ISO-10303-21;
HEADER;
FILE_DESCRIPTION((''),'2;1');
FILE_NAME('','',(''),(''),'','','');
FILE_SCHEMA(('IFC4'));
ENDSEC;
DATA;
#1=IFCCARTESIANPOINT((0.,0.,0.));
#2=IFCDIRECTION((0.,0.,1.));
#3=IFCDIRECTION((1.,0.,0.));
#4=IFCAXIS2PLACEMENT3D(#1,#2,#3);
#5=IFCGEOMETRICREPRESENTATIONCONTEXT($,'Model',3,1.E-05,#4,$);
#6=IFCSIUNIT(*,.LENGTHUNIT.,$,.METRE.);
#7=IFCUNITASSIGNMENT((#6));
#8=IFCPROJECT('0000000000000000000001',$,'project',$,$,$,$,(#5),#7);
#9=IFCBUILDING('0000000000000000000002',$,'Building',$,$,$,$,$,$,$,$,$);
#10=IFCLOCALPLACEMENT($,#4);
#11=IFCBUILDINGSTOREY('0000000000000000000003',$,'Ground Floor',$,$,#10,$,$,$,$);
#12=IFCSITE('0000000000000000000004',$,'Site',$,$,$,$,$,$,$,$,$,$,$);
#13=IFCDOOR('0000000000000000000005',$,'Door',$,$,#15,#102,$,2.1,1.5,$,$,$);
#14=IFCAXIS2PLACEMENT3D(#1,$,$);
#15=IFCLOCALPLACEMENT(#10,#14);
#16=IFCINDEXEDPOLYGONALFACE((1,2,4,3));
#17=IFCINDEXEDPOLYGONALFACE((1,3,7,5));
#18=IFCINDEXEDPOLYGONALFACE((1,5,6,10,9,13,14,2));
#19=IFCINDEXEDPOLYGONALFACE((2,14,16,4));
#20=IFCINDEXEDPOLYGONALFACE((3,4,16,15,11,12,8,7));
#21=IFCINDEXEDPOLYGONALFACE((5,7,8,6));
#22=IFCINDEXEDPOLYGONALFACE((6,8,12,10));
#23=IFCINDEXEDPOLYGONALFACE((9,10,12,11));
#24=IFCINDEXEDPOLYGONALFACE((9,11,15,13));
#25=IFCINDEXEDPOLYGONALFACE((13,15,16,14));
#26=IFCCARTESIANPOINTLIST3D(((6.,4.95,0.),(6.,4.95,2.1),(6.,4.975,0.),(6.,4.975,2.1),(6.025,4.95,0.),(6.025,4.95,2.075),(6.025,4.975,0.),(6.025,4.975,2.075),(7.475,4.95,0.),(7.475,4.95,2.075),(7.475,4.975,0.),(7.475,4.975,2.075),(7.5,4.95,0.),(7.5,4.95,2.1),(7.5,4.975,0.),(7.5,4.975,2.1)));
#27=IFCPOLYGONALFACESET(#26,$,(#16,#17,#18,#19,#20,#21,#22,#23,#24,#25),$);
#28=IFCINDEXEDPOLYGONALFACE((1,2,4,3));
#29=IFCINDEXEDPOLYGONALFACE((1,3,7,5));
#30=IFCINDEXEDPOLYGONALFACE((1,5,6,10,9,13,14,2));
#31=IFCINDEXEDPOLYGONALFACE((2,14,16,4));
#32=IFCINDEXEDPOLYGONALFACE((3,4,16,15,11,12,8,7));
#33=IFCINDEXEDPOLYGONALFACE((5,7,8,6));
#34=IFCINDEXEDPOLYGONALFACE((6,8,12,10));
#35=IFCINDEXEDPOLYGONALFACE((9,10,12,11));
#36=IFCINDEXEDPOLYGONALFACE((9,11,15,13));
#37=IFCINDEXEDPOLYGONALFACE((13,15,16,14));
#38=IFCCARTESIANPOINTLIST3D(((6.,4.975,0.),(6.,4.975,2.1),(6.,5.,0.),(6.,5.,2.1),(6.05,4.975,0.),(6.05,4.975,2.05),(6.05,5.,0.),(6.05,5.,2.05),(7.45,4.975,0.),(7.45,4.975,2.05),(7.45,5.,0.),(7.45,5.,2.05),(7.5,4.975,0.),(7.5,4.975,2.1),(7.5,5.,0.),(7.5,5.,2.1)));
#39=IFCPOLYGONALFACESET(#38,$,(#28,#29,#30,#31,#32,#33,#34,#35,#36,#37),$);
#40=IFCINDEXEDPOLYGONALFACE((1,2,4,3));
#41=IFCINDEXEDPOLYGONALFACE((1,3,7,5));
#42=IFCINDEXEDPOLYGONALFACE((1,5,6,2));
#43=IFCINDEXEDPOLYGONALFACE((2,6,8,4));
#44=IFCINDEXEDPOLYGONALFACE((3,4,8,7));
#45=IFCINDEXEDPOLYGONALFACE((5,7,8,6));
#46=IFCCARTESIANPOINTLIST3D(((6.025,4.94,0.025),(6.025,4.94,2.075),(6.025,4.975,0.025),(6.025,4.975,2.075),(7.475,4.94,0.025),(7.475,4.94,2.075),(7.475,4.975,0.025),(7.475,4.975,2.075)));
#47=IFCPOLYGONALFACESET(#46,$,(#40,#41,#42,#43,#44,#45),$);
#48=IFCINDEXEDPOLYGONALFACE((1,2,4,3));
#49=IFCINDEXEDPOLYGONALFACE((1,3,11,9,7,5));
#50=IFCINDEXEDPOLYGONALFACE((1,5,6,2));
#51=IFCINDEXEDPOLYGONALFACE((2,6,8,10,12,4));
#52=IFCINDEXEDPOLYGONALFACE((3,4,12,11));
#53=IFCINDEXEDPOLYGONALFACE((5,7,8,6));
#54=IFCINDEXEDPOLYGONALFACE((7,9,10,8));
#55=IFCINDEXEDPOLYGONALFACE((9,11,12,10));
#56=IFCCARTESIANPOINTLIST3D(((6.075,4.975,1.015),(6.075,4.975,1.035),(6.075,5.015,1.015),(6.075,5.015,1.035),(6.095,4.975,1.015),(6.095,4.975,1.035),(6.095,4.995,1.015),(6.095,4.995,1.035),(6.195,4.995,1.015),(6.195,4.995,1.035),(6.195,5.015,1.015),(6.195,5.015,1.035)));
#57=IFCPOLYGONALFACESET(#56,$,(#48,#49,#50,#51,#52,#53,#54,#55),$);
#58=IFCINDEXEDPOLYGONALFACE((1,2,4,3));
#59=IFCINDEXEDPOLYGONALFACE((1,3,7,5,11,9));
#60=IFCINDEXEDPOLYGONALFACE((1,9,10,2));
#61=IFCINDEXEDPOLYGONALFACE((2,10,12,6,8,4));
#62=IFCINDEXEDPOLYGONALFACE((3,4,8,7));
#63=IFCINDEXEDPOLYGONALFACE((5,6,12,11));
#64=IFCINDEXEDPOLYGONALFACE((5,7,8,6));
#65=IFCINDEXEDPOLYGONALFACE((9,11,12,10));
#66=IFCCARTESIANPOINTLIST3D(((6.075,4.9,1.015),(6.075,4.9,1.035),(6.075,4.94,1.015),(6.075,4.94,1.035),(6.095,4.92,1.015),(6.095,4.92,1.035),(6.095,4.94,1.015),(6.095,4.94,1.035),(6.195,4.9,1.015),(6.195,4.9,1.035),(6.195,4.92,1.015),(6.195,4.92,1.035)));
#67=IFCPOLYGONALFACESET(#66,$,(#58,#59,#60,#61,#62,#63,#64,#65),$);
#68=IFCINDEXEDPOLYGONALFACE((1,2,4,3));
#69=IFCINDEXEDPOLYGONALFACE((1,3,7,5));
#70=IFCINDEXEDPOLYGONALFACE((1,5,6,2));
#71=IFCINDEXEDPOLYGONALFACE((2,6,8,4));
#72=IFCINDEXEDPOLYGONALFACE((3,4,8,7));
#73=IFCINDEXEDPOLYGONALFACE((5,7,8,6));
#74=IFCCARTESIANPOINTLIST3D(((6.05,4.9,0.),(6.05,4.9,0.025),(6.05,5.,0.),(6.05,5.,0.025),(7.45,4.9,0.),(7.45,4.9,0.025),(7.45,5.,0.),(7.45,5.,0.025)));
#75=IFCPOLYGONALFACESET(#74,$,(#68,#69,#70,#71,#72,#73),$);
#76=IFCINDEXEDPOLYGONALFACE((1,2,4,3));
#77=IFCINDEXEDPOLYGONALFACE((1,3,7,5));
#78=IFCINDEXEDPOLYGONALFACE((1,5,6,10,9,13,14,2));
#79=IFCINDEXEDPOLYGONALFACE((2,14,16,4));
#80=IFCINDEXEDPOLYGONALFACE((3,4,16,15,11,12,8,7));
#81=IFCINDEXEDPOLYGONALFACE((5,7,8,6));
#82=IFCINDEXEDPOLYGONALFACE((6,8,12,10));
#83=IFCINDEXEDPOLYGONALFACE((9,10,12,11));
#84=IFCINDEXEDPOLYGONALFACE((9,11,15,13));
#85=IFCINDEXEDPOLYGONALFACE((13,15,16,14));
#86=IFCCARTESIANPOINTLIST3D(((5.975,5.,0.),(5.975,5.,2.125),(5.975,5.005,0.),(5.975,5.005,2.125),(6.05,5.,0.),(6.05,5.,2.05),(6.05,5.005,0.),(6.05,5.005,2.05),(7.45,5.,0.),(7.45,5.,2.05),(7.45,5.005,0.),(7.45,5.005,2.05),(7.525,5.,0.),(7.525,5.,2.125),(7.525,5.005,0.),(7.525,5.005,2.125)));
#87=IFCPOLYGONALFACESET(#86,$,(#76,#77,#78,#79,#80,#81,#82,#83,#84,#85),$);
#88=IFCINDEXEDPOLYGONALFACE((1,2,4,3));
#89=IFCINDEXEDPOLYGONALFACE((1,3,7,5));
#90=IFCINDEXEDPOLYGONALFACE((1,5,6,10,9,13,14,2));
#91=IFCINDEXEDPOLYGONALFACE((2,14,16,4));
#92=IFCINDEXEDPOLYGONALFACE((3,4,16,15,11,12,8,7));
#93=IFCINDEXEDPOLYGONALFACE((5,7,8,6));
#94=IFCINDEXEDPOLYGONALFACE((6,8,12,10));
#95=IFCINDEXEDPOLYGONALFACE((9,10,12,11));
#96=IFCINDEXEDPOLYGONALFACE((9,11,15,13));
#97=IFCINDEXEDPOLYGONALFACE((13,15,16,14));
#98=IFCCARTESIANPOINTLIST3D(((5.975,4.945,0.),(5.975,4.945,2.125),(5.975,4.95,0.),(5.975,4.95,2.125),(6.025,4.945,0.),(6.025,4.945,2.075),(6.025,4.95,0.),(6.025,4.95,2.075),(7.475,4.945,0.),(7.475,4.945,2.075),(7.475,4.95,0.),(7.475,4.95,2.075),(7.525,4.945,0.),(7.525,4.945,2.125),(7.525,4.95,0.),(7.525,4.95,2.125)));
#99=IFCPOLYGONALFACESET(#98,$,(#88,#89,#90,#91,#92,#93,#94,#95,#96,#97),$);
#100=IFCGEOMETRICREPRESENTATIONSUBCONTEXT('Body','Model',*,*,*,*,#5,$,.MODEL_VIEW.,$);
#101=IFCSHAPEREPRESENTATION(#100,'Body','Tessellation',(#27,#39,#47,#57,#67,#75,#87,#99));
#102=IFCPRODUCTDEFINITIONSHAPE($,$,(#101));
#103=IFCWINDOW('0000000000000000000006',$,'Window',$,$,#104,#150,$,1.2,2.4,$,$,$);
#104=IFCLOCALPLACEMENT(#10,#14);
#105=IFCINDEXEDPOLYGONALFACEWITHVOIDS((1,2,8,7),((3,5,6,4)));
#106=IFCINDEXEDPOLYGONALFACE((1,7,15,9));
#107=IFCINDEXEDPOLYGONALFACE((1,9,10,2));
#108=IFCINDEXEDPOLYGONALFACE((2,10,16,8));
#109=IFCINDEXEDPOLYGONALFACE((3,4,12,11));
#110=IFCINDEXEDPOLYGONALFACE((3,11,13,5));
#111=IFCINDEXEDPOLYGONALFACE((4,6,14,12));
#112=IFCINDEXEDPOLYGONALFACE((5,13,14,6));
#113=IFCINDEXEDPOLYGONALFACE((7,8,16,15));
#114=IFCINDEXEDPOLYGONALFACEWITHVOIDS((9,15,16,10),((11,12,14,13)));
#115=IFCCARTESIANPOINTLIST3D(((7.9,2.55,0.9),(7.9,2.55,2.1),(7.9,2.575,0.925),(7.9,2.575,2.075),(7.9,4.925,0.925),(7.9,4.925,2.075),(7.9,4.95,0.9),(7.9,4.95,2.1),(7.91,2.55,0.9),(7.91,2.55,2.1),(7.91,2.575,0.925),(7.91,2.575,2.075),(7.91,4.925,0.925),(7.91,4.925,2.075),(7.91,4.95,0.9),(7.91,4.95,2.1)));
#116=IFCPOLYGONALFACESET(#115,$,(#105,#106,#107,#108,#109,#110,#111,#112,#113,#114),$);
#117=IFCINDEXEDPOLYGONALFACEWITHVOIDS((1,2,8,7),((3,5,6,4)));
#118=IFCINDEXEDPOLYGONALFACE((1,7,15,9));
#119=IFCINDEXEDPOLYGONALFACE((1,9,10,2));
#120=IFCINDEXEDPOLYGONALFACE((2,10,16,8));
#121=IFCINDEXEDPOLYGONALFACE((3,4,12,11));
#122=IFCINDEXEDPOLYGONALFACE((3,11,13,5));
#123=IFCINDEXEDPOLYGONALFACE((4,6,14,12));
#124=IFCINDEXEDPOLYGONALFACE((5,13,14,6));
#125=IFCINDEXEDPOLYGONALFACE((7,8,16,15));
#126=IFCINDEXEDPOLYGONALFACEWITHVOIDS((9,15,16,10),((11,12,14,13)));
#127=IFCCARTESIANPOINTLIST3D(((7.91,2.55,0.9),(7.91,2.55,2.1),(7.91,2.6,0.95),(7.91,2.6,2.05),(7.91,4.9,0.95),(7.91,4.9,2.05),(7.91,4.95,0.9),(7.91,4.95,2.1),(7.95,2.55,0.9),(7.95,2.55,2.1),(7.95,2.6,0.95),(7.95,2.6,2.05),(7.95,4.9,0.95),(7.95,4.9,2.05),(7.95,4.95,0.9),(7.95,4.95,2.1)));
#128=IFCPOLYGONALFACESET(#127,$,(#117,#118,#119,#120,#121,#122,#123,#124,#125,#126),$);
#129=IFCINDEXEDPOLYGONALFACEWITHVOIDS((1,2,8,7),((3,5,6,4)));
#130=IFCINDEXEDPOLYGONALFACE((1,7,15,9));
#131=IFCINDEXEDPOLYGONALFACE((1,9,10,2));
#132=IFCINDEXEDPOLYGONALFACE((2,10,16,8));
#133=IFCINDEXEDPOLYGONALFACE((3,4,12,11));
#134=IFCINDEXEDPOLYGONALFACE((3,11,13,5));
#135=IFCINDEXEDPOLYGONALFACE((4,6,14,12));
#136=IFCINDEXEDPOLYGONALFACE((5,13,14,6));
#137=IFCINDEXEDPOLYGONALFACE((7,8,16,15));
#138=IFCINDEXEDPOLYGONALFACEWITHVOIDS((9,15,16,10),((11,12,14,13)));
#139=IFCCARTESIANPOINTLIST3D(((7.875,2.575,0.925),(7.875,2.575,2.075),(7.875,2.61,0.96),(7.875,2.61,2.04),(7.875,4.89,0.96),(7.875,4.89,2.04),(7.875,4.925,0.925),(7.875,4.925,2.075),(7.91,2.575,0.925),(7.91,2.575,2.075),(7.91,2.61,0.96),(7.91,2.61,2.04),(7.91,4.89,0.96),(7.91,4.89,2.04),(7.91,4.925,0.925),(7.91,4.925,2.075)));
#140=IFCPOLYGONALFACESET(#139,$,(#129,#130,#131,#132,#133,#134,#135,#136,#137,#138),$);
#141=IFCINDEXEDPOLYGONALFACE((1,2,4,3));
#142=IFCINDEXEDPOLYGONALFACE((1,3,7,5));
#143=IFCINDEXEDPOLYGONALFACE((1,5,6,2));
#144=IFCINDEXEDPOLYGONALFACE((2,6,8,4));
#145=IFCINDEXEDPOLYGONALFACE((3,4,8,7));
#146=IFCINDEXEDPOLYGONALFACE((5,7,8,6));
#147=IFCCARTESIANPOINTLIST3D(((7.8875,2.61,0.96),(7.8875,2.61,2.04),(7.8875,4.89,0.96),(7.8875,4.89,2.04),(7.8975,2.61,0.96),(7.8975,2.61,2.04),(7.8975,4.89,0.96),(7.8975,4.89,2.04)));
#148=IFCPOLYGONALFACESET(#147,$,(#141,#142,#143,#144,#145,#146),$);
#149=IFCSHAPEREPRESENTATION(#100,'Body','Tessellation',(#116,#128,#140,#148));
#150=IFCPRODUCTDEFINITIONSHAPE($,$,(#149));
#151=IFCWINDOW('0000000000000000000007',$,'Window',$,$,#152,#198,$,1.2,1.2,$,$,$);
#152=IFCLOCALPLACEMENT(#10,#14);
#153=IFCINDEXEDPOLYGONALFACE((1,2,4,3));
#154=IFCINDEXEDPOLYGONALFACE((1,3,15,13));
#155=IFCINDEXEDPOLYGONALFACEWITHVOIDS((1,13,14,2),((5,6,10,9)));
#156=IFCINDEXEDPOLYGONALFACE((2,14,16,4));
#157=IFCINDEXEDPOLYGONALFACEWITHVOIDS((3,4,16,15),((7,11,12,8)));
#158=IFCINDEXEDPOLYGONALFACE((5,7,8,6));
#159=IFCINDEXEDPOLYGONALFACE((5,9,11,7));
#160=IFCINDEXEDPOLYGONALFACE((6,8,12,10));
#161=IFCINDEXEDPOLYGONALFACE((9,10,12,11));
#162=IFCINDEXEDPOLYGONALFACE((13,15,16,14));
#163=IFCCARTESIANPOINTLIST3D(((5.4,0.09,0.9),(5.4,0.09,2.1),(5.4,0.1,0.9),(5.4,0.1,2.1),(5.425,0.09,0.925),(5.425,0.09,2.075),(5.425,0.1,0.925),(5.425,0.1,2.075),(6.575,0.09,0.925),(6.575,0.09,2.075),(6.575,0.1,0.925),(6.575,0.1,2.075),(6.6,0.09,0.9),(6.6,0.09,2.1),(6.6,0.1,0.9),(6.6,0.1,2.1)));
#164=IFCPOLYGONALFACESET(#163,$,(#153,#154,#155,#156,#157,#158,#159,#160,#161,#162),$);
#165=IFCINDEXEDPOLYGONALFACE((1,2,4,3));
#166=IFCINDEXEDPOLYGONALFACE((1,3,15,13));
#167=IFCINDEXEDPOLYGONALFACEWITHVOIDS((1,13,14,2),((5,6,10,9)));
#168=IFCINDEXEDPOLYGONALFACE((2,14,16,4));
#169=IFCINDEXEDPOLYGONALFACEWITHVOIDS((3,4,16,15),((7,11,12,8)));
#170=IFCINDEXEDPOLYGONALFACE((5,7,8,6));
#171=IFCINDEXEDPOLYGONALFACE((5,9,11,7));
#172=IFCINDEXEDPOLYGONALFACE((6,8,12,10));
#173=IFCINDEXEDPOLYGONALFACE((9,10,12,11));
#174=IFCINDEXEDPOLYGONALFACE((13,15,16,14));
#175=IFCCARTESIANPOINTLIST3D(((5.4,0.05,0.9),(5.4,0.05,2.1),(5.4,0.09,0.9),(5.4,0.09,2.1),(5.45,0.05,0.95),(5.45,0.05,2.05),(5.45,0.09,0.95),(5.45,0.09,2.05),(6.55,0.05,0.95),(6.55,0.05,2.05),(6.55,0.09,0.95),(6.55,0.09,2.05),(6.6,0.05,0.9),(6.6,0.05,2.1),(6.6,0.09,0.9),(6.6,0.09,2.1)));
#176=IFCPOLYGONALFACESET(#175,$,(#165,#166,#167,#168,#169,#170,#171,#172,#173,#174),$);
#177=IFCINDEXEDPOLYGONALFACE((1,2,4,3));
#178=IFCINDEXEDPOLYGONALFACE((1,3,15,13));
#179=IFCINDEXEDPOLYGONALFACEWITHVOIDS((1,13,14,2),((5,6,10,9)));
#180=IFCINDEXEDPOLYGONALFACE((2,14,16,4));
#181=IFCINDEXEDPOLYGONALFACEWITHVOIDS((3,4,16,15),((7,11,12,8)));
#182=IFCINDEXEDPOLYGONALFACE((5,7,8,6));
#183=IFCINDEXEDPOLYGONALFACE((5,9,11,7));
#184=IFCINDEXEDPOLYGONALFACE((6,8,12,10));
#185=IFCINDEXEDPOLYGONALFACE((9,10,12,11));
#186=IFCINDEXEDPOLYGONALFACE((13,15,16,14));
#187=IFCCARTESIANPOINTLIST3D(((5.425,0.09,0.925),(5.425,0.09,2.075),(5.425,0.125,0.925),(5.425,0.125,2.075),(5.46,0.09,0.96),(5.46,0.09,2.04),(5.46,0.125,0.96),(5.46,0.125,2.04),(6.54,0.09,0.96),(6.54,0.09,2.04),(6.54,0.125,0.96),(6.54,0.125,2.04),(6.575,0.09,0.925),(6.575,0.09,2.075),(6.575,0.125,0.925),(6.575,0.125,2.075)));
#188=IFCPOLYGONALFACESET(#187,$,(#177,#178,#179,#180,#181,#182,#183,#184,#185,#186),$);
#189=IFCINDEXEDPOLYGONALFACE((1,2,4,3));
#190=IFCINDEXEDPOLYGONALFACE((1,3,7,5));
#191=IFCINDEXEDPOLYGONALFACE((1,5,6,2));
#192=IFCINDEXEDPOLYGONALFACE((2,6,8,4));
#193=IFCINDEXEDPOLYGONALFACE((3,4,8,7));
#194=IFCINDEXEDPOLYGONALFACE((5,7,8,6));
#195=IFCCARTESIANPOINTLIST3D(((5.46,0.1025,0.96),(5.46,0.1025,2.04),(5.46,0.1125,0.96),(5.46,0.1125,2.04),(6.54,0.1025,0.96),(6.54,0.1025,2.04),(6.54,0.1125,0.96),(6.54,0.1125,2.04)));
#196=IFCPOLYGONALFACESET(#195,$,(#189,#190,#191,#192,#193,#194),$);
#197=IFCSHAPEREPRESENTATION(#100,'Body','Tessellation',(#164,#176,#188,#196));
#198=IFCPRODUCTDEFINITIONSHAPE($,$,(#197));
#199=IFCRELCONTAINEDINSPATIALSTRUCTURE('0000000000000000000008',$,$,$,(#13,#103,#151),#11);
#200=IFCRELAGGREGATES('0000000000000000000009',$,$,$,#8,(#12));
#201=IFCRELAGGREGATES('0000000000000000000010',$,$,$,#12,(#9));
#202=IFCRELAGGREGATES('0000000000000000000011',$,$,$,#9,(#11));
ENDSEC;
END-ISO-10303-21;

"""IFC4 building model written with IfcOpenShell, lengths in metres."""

from ifc_helpers import new_model, si_unit, frame, origin_with_axes, place, context, subcontext, project, spatial, line, indexed_curve, outline, extrude, element, save


model = new_model("IFC4")

# Units and contexts
model_context = context("Model", 3, precision=1e-05, world=origin_with_axes())
body_context = subcontext(model_context, "Body", "Model", "MODEL_VIEW")
ifc_project = project(units=[si_unit("LENGTHUNIT", "METRE")], contexts=[model_context])

# Site, building, storey
site = spatial("IfcSite", under=ifc_project, Name="Site")
building = spatial("IfcBuilding", under=site, Name="Building")
storey_placement = place(None, origin_with_axes())
storey = spatial("IfcBuildingStorey", under=building, at=storey_placement, Name="Ground Floor")

# Door
door_1_placement = place(storey_placement, frame((7.5, 5.0, 0.0), z_axis=(0.0, 0.0, 1.0), x_axis=(-1.0, 0.0, 0.0)))
element("IfcDoor", 1, at=door_1_placement, inside=storey, Name="Door", OverallHeight=2.1, OverallWidth=1.5, context=body_context, shape_type="SweptSolid", body=[
    extrude(outline(indexed_curve([(0.0, 0.0), (0.0, 2.1), (1.5, 2.1), (1.5, 0.0), (1.475, 0.0), (1.475, 2.075), (0.025, 2.075), (0.025, 0.0)], segments=[line(1, 2, 3, 4, 5, 6, 7, 8, 1)])), frame((0.0, 0.025, 0.0), z_axis=(0.0, -1.0, 0.0), x_axis=(1.0, 0.0, 0.0)), (0.0, 0.0, -1.0), 0.025),
    extrude(outline(indexed_curve([(0.0, 0.0), (0.0, 2.1), (1.5, 2.1), (1.5, 0.0), (1.45, 0.0), (1.45, 2.05), (0.05, 2.05), (0.05, 0.0)], segments=[line(1, 2, 3, 4, 5, 6, 7, 8, 1)])), frame((0.0, 0.0, 0.0), z_axis=(0.0, -1.0, 0.0), x_axis=(1.0, 0.0, 0.0)), (0.0, 0.0, -1.0), 0.025),
    extrude(outline(indexed_curve([(0.0, 0.0), (1.45, 0.0), (1.45, 0.035), (0.0, 0.035)], segments=[line(1, 2, 3, 4, 1)])), frame((0.025, 0.025, 0.025), z_axis=(0.0, 0.0, 1.0), x_axis=(1.0, 0.0, 0.0)), (0.0, 0.0, 1.0), 2.05),
    extrude(outline(indexed_curve([(0.0, 0.0), (0.0, -0.04), (-0.12, -0.04), (-0.12, -0.02), (-0.02, -0.02), (-0.02, 0.0)], segments=[line(1, 2, 3, 4, 5, 6, 1)])), frame((1.425, 0.025, 1.015), z_axis=(0.0, 0.0, 1.0), x_axis=(1.0, 0.0, 0.0)), (0.0, 0.0, 1.0), 0.02),
    extrude(outline(indexed_curve([(0.0, 0.0), (0.0, 0.04), (-0.12, 0.04), (-0.12, 0.02), (-0.02, 0.02), (-0.02, 0.0)], segments=[line(1, 2, 3, 4, 5, 6, 1)])), frame((1.425, 0.06, 1.015), z_axis=(0.0, 0.0, 1.0), x_axis=(1.0, 0.0, 0.0)), (0.0, 0.0, 1.0), 0.02),
    extrude(outline(indexed_curve([(0.0, 0.0), (1.4, 0.0), (1.4, 0.1), (0.0, 0.1)], segments=[line(1, 2, 3, 4, 1)])), frame((0.05, 0.0, 0.0), z_axis=(0.0, 0.0, 1.0), x_axis=(1.0, 0.0, 0.0)), (0.0, 0.0, 1.0), 0.025),
    extrude(outline(indexed_curve([(0.0, 0.0), (0.0, 2.125), (1.55, 2.125), (1.55, 0.0), (1.475, 0.0), (1.475, 2.05), (0.075, 2.05), (0.075, 0.0)], segments=[line(1, 2, 3, 4, 5, 6, 7, 8, 1)])), frame((-0.025, -0.005, 0.0), z_axis=(0.0, -1.0, 0.0), x_axis=(1.0, 0.0, 0.0)), (0.0, 0.0, -1.0), 0.005),
    extrude(outline(indexed_curve([(0.0, 0.0), (0.0, 2.125), (1.55, 2.125), (1.55, 0.0), (1.5, 0.0), (1.5, 2.075), (0.05, 2.075), (0.05, 0.0)], segments=[line(1, 2, 3, 4, 5, 6, 7, 8, 1)])), frame((-0.025, 0.05, 0.0), z_axis=(0.0, -1.0, 0.0), x_axis=(1.0, 0.0, 0.0)), (0.0, 0.0, -1.0), 0.005),
])

# Windows
window_placement = place(storey_placement, frame((8.0, 2.55, 0.9), z_axis=(0.0, 0.0, 1.0), x_axis=(0.0, 1.0, 0.0)))
element("IfcWindow", 2, at=window_placement, inside=storey, Name="Window", OverallHeight=1.2, OverallWidth=2.4, context=body_context, shape_type="SweptSolid", body=[
    extrude(outline(indexed_curve([(0.0, 0.0), (2.4, 0.0), (2.4, 1.2), (0.0, 1.2)], segments=[line(1, 2, 3, 4, 1)]), holes=[indexed_curve([(0.025, 0.025), (2.375, 0.025), (2.375, 1.175), (0.025, 1.175)], segments=[line(1, 2, 3, 4, 1)])]), frame((0.0, 0.09, 0.0), z_axis=(0.0, -1.0, 0.0), x_axis=(1.0, 0.0, 0.0)), (0.0, 0.0, -1.0), 0.01),
    extrude(outline(indexed_curve([(0.0, 0.0), (2.4, 0.0), (2.4, 1.2), (0.0, 1.2)], segments=[line(1, 2, 3, 4, 1)]), holes=[indexed_curve([(0.05, 0.05), (2.35, 0.05), (2.35, 1.15), (0.05, 1.15)], segments=[line(1, 2, 3, 4, 1)])]), frame((0.0, 0.05, 0.0), z_axis=(0.0, -1.0, 0.0), x_axis=(1.0, 0.0, 0.0)), (0.0, 0.0, -1.0), 0.04),
    extrude(outline(indexed_curve([(0.0, 0.0), (2.35, 0.0), (2.35, 1.15), (0.0, 1.15)], segments=[line(1, 2, 3, 4, 1)]), holes=[indexed_curve([(0.035, 0.035), (2.315, 0.035), (2.315, 1.115), (0.035, 1.115)], segments=[line(1, 2, 3, 4, 1)])]), frame((0.025, 0.09, 0.025), z_axis=(0.0, -1.0, 0.0), x_axis=(1.0, 0.0, 0.0)), (0.0, 0.0, -1.0), 0.035),
    extrude(outline(indexed_curve([(0.035, 0.035), (2.315, 0.035), (2.315, 1.115), (0.035, 1.115)], segments=[line(1, 2, 3, 4, 1)])), frame((0.025, 0.1025, 0.025), z_axis=(0.0, -1.0, 0.0), x_axis=(1.0, 0.0, 0.0)), (0.0, 0.0, -1.0), 0.01),
])
for number, where, z_axis, x_axis, name in (
    (3, (5.4, 0.0, 0.9), (0.0, 0.0, 1.0), (1.0, 0.0, 0.0), "Window"),
):
    element("IfcWindow", number, at=place(storey_placement, frame(where, z_axis=z_axis, x_axis=x_axis)), inside=storey, Name=name, OverallHeight=1.2, OverallWidth=1.2, context=body_context, shape_type="SweptSolid", body=[
        extrude(outline(indexed_curve([(0.0, 0.0), (1.2, 0.0), (1.2, 1.2), (0.0, 1.2)], segments=[line(1, 2, 3, 4, 1)]), holes=[indexed_curve([(0.025, 0.025), (1.175, 0.025), (1.175, 1.175), (0.025, 1.175)], segments=[line(1, 2, 3, 4, 1)])]), frame((0.0, 0.09, 0.0), z_axis=(0.0, -1.0, 0.0), x_axis=(1.0, 0.0, 0.0)), (0.0, 0.0, -1.0), 0.01),
        extrude(outline(indexed_curve([(0.0, 0.0), (1.2, 0.0), (1.2, 1.2), (0.0, 1.2)], segments=[line(1, 2, 3, 4, 1)]), holes=[indexed_curve([(0.05, 0.05), (1.15, 0.05), (1.15, 1.15), (0.05, 1.15)], segments=[line(1, 2, 3, 4, 1)])]), frame((0.0, 0.05, 0.0), z_axis=(0.0, -1.0, 0.0), x_axis=(1.0, 0.0, 0.0)), (0.0, 0.0, -1.0), 0.04),
        extrude(outline(indexed_curve([(0.0, 0.0), (1.15, 0.0), (1.15, 1.15), (0.0, 1.15)], segments=[line(1, 2, 3, 4, 1)]), holes=[indexed_curve([(0.035, 0.035), (1.115, 0.035), (1.115, 1.115), (0.035, 1.115)], segments=[line(1, 2, 3, 4, 1)])]), frame((0.025, 0.09, 0.025), z_axis=(0.0, -1.0, 0.0), x_axis=(1.0, 0.0, 0.0)), (0.0, 0.0, -1.0), 0.035),
        extrude(outline(indexed_curve([(0.035, 0.035), (1.115, 0.035), (1.115, 1.115), (0.035, 1.115)], segments=[line(1, 2, 3, 4, 1)])), frame((0.025, 0.1025, 0.025), z_axis=(0.0, -1.0, 0.0), x_axis=(1.0, 0.0, 0.0)), (0.0, 0.0, -1.0), 0.01),
    ])

save(model, "model.ifc")
